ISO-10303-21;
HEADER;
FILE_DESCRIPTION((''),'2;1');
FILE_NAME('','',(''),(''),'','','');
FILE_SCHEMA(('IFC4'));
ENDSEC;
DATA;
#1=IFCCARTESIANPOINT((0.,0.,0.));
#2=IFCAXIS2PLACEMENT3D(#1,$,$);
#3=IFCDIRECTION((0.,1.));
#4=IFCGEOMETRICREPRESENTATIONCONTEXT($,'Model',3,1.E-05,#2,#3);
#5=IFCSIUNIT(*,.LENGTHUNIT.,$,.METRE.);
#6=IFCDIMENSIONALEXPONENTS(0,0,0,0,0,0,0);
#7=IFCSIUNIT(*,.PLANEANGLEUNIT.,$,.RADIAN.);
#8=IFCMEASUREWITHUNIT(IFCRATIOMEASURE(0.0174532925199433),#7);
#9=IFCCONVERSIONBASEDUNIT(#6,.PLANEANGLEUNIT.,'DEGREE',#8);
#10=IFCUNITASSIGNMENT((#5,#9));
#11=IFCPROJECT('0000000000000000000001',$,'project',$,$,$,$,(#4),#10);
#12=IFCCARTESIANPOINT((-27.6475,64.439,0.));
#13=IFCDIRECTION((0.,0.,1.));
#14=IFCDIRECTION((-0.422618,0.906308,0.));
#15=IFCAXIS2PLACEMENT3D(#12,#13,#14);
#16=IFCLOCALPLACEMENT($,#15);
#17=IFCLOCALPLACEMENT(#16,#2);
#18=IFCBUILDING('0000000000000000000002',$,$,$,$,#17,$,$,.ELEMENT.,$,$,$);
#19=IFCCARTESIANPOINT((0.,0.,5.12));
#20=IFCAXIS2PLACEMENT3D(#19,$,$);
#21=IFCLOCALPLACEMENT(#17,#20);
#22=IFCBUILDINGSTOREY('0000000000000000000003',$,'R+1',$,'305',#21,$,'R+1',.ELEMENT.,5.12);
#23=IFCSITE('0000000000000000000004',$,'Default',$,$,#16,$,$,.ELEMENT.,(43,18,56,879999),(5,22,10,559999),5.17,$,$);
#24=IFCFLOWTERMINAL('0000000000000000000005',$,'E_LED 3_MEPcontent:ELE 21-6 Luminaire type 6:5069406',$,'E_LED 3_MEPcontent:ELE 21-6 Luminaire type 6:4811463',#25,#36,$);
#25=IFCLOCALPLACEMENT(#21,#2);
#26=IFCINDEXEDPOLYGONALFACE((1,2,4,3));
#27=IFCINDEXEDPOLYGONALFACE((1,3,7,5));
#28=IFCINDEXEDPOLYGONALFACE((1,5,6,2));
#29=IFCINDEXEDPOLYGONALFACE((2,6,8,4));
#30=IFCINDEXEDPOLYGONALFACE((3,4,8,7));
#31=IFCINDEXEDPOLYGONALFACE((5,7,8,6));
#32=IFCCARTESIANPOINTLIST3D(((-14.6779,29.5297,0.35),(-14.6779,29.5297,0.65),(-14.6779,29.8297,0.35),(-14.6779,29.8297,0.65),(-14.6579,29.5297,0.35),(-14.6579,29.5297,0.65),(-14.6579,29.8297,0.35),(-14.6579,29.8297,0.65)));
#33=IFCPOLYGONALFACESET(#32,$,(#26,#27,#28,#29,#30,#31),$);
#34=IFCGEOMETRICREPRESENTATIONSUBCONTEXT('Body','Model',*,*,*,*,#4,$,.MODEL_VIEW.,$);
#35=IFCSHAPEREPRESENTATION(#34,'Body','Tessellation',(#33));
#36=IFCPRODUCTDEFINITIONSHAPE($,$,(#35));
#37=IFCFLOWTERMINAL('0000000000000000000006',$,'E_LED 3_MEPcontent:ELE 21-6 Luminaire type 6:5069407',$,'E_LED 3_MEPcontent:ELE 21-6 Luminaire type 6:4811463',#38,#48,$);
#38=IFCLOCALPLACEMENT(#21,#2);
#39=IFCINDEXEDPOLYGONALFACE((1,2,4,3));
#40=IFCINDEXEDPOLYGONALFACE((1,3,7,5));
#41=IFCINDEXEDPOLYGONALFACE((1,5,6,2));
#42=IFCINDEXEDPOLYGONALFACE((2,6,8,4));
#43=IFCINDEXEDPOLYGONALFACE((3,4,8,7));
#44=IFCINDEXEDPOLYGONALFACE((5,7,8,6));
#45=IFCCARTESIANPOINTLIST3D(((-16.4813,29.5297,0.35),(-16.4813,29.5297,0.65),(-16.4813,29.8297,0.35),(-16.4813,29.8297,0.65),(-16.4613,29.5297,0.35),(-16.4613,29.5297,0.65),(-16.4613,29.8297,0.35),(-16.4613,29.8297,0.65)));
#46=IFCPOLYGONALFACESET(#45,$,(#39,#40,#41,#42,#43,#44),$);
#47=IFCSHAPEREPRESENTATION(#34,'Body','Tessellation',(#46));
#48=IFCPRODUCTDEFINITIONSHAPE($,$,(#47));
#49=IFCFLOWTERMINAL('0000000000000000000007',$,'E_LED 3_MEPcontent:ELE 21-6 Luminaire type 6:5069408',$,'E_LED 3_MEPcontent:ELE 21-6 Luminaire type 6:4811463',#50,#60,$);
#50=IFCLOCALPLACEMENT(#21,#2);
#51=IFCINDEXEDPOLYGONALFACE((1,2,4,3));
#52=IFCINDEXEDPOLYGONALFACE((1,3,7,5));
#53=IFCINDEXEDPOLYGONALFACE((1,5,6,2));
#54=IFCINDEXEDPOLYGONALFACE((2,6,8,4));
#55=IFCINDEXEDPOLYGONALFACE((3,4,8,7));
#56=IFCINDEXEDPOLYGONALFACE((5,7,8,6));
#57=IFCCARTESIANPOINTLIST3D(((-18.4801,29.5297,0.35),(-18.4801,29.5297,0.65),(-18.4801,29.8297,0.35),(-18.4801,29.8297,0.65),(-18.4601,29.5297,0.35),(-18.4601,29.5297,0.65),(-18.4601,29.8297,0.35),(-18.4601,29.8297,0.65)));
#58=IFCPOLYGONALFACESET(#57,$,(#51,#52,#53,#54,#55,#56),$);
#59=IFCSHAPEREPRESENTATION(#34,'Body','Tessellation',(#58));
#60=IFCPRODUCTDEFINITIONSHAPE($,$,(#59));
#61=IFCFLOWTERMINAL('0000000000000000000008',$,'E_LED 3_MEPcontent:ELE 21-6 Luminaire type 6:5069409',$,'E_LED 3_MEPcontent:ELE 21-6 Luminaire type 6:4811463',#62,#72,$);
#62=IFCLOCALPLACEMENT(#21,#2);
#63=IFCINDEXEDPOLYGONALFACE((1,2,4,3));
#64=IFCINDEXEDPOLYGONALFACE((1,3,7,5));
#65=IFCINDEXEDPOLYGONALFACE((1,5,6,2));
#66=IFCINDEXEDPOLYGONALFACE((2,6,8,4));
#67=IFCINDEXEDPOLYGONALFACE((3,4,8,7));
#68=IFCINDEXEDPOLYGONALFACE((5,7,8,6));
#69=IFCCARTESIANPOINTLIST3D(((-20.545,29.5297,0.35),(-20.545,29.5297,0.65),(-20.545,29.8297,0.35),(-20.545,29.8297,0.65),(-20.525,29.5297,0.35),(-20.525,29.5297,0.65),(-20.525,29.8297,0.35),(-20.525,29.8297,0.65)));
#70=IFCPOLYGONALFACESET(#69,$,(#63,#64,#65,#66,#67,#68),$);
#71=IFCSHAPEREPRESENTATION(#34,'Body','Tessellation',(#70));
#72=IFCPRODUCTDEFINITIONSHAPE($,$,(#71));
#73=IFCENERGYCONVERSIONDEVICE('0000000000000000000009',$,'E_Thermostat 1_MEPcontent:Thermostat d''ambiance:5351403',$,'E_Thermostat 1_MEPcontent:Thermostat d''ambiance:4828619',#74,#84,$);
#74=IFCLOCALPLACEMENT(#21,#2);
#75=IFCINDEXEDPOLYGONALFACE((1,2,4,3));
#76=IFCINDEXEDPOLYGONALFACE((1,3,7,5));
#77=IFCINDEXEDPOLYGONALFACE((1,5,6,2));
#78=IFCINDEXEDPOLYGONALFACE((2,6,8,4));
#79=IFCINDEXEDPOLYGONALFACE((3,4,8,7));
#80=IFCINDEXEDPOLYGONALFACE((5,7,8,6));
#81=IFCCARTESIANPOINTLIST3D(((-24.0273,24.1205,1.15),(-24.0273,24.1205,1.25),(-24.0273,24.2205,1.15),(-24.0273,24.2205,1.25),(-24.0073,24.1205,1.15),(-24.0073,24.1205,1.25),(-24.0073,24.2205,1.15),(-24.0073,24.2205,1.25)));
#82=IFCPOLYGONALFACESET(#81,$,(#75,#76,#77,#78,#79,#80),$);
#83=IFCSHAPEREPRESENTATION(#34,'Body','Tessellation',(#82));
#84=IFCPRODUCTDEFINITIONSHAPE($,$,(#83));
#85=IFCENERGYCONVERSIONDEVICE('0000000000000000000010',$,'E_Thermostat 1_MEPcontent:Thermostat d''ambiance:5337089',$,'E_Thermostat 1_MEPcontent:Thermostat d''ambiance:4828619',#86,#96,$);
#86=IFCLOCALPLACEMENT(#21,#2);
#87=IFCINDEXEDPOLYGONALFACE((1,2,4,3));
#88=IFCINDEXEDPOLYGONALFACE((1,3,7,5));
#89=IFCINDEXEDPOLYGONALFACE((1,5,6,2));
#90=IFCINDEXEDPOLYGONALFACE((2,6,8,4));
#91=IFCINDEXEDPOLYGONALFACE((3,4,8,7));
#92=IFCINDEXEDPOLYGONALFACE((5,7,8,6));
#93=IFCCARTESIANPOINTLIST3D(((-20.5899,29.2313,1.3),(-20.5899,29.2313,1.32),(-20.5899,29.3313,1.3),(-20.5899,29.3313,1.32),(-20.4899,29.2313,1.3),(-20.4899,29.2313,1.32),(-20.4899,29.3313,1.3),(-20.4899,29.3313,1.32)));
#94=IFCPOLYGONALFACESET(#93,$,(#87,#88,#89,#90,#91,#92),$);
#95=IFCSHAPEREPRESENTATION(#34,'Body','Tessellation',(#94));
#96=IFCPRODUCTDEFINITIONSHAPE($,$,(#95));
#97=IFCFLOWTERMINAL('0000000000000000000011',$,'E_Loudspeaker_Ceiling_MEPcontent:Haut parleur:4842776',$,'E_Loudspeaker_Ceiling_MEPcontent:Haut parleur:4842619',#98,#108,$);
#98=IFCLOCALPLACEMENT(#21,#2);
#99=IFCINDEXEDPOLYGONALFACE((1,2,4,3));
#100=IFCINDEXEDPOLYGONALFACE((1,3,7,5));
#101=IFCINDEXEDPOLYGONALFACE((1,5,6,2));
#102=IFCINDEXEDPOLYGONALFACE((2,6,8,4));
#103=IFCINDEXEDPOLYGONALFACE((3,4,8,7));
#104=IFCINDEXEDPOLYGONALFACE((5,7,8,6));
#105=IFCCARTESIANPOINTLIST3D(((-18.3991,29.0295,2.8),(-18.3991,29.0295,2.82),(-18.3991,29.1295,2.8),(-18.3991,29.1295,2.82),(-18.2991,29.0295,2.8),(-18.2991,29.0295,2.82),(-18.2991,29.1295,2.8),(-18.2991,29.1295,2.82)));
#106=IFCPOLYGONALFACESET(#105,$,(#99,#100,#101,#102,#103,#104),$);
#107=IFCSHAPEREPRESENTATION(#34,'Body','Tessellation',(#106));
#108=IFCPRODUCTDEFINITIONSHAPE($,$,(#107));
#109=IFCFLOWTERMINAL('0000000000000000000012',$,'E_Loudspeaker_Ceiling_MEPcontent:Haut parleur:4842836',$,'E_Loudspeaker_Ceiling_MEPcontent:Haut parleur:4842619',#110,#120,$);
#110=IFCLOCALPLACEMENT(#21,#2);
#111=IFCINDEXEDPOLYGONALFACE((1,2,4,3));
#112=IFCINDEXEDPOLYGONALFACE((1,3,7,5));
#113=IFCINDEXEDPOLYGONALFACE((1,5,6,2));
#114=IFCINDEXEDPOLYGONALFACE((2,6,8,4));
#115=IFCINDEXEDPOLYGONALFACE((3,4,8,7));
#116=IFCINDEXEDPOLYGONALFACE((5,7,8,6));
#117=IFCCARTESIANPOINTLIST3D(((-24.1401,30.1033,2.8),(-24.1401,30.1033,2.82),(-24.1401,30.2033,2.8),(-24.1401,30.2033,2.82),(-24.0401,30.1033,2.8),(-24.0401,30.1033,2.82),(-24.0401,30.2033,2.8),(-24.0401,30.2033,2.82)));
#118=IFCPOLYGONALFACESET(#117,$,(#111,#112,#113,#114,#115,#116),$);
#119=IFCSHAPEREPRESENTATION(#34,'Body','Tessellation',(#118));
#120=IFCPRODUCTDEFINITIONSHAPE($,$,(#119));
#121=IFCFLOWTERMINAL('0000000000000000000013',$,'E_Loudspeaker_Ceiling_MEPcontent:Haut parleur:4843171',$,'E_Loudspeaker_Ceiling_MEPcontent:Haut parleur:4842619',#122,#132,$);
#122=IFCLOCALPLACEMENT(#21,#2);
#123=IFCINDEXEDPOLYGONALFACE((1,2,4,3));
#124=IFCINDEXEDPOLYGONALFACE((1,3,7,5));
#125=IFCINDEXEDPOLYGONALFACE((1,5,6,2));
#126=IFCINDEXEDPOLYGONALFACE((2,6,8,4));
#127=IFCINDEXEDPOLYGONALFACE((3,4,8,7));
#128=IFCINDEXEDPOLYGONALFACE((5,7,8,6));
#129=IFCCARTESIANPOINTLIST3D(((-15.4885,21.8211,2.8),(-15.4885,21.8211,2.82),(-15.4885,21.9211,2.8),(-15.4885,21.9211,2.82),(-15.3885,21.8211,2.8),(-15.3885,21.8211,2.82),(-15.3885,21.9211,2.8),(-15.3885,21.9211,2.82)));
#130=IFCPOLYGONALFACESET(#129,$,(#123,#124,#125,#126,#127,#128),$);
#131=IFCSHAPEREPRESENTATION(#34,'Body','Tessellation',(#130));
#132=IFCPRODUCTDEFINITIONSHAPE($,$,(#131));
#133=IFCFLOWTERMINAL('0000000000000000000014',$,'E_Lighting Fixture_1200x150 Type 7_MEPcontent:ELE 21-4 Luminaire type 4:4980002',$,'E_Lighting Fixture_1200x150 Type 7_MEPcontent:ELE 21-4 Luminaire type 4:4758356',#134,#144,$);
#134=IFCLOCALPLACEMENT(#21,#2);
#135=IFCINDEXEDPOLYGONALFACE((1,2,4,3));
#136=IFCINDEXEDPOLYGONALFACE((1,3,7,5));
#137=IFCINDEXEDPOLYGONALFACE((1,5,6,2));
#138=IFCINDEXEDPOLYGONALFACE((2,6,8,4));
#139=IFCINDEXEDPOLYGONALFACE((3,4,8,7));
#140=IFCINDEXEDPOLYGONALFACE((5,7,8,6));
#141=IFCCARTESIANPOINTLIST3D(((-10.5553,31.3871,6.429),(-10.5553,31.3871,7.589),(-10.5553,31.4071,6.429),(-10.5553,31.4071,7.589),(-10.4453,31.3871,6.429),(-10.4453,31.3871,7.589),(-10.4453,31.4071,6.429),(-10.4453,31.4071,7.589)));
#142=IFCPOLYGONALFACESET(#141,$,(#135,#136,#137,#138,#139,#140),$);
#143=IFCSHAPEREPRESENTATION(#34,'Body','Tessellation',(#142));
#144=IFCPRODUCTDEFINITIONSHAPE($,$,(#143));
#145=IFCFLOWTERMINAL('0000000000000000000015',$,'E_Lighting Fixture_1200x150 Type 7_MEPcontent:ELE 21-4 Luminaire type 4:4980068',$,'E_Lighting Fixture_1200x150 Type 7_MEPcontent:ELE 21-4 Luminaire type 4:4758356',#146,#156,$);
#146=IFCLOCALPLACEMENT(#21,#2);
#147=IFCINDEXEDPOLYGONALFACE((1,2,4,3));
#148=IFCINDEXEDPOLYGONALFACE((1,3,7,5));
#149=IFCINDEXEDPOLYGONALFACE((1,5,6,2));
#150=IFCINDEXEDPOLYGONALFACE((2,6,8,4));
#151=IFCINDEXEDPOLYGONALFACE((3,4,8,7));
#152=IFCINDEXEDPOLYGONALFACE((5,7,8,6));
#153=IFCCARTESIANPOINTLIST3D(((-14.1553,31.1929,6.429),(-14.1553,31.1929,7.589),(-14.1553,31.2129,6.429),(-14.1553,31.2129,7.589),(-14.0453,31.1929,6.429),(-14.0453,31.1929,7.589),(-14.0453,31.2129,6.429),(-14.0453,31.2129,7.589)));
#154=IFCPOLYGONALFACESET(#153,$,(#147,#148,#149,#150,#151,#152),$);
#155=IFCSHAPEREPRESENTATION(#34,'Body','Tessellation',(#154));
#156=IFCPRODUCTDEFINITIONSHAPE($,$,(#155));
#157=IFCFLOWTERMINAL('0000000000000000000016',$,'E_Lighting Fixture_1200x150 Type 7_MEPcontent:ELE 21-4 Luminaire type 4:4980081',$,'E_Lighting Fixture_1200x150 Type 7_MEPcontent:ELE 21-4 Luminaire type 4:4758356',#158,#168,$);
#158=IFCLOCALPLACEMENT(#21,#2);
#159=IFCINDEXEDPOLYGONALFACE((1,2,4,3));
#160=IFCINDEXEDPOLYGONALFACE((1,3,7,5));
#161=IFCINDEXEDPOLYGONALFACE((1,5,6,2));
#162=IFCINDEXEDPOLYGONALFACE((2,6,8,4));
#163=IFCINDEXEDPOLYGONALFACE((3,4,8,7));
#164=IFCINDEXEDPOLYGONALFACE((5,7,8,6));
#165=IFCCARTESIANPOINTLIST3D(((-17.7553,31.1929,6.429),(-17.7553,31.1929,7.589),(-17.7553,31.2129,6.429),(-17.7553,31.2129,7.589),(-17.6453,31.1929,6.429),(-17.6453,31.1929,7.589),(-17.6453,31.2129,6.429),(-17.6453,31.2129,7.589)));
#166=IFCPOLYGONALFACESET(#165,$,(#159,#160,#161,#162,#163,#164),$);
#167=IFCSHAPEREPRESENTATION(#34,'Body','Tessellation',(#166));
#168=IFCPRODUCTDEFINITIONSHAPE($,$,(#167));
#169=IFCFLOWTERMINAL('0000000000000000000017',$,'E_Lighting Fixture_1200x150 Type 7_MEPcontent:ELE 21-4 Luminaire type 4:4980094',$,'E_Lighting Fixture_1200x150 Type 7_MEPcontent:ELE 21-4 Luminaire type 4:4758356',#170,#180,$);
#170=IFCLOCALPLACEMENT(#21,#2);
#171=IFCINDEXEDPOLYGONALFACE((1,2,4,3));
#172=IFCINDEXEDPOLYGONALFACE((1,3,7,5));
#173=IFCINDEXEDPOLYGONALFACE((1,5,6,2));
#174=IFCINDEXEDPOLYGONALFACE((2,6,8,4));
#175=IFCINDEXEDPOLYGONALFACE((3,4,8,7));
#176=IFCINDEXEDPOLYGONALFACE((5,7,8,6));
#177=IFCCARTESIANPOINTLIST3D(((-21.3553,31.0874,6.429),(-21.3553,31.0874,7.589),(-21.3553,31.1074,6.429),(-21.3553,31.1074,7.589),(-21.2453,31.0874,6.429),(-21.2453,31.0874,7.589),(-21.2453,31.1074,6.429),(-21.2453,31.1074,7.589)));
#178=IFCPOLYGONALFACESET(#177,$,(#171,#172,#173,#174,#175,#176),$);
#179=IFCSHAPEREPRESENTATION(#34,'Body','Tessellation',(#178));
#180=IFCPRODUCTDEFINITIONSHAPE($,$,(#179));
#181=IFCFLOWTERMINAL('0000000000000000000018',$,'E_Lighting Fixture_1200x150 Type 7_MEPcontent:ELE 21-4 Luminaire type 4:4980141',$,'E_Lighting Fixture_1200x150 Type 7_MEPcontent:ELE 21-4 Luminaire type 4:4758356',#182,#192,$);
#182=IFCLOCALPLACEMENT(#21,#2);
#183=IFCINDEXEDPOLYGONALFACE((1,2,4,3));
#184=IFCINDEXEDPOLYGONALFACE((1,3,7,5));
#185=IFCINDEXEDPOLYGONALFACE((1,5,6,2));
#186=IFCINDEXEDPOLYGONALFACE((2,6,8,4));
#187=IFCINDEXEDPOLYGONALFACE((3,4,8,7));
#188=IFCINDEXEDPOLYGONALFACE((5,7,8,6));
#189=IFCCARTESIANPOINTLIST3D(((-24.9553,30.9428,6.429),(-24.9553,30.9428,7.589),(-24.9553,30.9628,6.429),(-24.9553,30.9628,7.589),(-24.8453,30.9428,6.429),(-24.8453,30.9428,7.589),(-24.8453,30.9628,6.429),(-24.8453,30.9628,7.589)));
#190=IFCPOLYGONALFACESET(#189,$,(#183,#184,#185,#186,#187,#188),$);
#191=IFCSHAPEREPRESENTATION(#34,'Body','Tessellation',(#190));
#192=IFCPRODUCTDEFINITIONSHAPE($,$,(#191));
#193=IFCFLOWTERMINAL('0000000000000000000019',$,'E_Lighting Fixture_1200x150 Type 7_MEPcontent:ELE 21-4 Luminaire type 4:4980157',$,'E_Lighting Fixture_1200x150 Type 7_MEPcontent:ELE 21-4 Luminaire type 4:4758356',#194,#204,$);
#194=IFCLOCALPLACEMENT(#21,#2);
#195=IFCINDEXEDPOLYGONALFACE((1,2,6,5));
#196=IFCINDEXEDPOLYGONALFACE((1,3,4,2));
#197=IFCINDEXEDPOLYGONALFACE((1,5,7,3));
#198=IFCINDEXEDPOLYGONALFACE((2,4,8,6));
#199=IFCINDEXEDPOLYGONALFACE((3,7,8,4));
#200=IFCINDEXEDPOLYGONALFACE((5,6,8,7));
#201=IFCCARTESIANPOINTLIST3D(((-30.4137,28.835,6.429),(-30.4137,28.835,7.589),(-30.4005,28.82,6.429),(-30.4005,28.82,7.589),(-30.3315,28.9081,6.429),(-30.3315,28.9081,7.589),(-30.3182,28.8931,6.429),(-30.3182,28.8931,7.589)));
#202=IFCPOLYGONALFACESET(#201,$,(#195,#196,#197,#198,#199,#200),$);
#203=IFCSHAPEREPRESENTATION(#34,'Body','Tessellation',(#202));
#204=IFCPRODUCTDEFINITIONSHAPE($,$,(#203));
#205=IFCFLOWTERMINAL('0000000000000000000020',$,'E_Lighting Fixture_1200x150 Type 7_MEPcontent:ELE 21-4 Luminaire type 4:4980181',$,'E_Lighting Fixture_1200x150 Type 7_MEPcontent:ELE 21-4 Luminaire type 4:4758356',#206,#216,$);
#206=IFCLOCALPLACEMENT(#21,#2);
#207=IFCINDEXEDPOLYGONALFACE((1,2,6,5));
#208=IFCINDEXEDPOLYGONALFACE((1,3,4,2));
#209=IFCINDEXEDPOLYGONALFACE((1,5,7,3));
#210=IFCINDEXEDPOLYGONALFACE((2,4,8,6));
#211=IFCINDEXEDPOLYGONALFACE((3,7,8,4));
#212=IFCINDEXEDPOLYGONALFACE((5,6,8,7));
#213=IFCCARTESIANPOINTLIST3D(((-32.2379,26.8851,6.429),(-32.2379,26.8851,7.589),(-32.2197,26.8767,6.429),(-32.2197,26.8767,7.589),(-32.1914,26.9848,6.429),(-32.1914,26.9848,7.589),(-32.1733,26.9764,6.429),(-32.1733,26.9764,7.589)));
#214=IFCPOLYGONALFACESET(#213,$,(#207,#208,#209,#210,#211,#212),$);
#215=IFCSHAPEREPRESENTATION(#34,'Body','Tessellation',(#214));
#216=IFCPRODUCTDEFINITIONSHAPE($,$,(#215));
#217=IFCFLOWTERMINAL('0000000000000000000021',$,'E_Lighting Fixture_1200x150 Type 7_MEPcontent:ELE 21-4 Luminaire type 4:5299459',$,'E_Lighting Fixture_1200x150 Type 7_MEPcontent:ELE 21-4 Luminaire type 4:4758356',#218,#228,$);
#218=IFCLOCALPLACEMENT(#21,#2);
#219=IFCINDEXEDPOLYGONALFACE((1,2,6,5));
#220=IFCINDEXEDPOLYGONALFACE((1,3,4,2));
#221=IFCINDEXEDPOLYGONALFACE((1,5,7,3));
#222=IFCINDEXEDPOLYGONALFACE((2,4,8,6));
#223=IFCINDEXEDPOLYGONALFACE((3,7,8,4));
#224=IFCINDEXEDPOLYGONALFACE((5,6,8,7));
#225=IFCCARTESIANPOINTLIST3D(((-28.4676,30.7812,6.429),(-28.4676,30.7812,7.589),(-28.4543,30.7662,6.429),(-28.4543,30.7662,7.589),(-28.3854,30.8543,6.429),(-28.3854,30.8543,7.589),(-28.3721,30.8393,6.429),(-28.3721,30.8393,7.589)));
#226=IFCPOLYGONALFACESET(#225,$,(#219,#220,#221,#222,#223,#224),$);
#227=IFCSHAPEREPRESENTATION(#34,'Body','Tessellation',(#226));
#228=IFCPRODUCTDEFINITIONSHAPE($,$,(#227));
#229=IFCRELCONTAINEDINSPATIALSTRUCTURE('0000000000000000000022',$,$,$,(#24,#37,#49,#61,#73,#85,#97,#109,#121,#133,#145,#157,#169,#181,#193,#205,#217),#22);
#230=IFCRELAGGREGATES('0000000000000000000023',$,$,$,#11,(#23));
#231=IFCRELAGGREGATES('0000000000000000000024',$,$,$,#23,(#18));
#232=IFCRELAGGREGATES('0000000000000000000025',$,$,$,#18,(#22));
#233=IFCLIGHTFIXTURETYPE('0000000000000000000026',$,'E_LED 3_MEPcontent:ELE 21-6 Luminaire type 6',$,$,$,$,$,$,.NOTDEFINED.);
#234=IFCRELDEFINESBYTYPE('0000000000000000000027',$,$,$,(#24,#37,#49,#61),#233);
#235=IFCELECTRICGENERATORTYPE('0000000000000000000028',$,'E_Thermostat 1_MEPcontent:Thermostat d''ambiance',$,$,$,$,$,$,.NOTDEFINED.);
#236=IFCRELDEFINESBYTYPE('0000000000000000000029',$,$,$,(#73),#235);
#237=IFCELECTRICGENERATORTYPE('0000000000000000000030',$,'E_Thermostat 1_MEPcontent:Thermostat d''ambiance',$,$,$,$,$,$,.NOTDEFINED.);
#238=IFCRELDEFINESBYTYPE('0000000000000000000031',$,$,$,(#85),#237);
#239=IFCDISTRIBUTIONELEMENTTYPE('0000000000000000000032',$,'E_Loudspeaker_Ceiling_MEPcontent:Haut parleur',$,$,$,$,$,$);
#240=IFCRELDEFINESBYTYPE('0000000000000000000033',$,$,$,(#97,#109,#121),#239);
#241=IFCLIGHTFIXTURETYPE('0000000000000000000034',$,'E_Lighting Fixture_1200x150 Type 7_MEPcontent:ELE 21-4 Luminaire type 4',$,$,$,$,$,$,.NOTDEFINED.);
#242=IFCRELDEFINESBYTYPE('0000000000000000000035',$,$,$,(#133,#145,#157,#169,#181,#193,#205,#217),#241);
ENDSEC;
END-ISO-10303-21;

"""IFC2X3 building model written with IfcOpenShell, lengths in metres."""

from ifc_helpers import new_model, entity, si_unit, converted_unit, direction, frame, frame_2d, origin, origin_2d_with_axis, place, context, subcontext, project, spatial, rectangle, extrude, source, transform, mapped, type_object, type_shapes, element, save


model = new_model("IFC2X3")

# Units and contexts
model_context = context("Model", 3, precision=1e-05, world=origin(), true_north=direction((0.0, 1.0)))
body_context = subcontext(model_context, "Body", "Model", "MODEL_VIEW")
ifc_project = project(units=[si_unit("LENGTHUNIT", "METRE"), converted_unit("PLANEANGLEUNIT", "DEGREE", entity("IfcRatioMeasure", 0.0174532925199433), si_unit("PLANEANGLEUNIT", "RADIAN"), dimensions=[0, 0, 0, 0, 0, 0, 0])], contexts=[model_context])

# Site, building, storey
site_placement = place(None, frame((-27.6475, 64.439, 0.0), z_axis=(0.0, 0.0, 1.0), x_axis=(-0.422618, 0.906308, 0.0)))
site = spatial("IfcSite", under=ifc_project, at=site_placement, Name="Default", CompositionType="ELEMENT", RefLatitude=(43, 18, 56, 879999), RefLongitude=(5, 22, 10, 559999), RefElevation=5.17)
building_placement = place(site_placement, origin())
building = spatial("IfcBuilding", under=site, at=building_placement, CompositionType="ELEMENT")
storey_placement = place(building_placement, frame((0.0, 0.0, 5.12)))
storey = spatial("IfcBuildingStorey", under=building, at=storey_placement, Name="R+1", ObjectType="305", LongName="R+1", CompositionType="ELEMENT", Elevation=5.12)

# Flow terminals
light_fixture_type_1 = type_object("IfcLightFixtureType", Name="E_LED 3_MEPcontent:ELE 21-6 Luminaire type 6", PredefinedType="NOTDEFINED")
shared_shape_1 = source(origin(), body_context, "Body", "SweptSolid", [
    extrude(rectangle(XDim=0.02, YDim=0.3, at=origin_2d_with_axis()), frame((0.0, 0.01, -0.15), z_axis=(0.0, 0.0, 1.0), x_axis=(0.0, -1.0, 0.0)), (0.0, 0.0, 1.0), 0.3),
])
type_shapes(light_fixture_type_1, [shared_shape_1])
for number, where, z_axis, x_axis, name in (
    (1, (-14.6779, 29.6797, 0.5), (0.0, 0.0, 1.0), (0.0, -1.0, 0.0), "E_LED 3_MEPcontent:ELE 21-6 Luminaire type 6:5069406"),
    (2, (-16.4813, 29.6797, 0.5), (0.0, 0.0, 1.0), (0.0, -1.0, 0.0), "E_LED 3_MEPcontent:ELE 21-6 Luminaire type 6:5069407"),
    (3, (-18.4801, 29.6797, 0.5), (0.0, 0.0, 1.0), (0.0, -1.0, 0.0), "E_LED 3_MEPcontent:ELE 21-6 Luminaire type 6:5069408"),
    (4, (-20.545, 29.6797, 0.5), (0.0, 0.0, 1.0), (0.0, -1.0, 0.0), "E_LED 3_MEPcontent:ELE 21-6 Luminaire type 6:5069409"),
):
    element("IfcFlowTerminal", number, at=place(storey_placement, frame(where, z_axis=z_axis, x_axis=x_axis)), inside=storey, type_object=light_fixture_type_1, Name=name, ObjectType="E_LED 3_MEPcontent:ELE 21-6 Luminaire type 6:4811463", context=body_context, shape_type="MappedRepresentation", body=[
        mapped(shared_shape_1, transform((0.0, 0.0, 0.0), scale=1.0)),
    ])

# Energy conversion devices
electric_generator_type_1 = type_object("IfcElectricGeneratorType", Name="E_Thermostat 1_MEPcontent:Thermostat d'ambiance", PredefinedType="NOTDEFINED")
shared_shape_2 = source(origin(), body_context, "Body", "SweptSolid", [
    extrude(rectangle(XDim=0.02, YDim=0.1, at=frame_2d((0.0, 0.0), x_axis=(1.0, 0.0))), frame((0.0, 0.01, -0.05), z_axis=(0.0, 0.0, 1.0), x_axis=(0.0, -1.0, 0.0)), (0.0, 0.0, 1.0), 0.1),
])
type_shapes(electric_generator_type_1, [shared_shape_2])
energy_conversion_device_1_placement = place(storey_placement, frame((-24.0073, 24.1705, 1.2), z_axis=(0.0, 0.0, 1.0), x_axis=(0.0, 1.0, 0.0)))
element("IfcEnergyConversionDevice", 5, at=energy_conversion_device_1_placement, inside=storey, type_object=electric_generator_type_1, Name="E_Thermostat 1_MEPcontent:Thermostat d'ambiance:5351403", ObjectType="E_Thermostat 1_MEPcontent:Thermostat d'ambiance:4828619", context=body_context, shape_type="MappedRepresentation", body=[
    mapped(shared_shape_2, transform((0.0, 0.0, 0.0), scale=1.0)),
])
electric_generator_type_2 = type_object("IfcElectricGeneratorType", Name="E_Thermostat 1_MEPcontent:Thermostat d'ambiance", PredefinedType="NOTDEFINED")
shared_shape_3 = source(origin(), body_context, "Body", "SweptSolid", [
    extrude(rectangle(XDim=0.1, YDim=0.1, at=origin_2d_with_axis()), frame((0.0, 0.0, 0.0), z_axis=(0.0, 0.0, 1.0), x_axis=(0.0, -1.0, 0.0)), (0.0, 0.0, 1.0), 0.02),
])
type_shapes(electric_generator_type_2, [shared_shape_3])
energy_conversion_device_2_placement = place(storey_placement, frame((-20.5399, 29.2813, 1.3), z_axis=(0.0, 0.0, 1.0), x_axis=(-1.0, 0.0, 0.0)))
element("IfcEnergyConversionDevice", 6, at=energy_conversion_device_2_placement, inside=storey, type_object=electric_generator_type_2, Name="E_Thermostat 1_MEPcontent:Thermostat d'ambiance:5337089", ObjectType="E_Thermostat 1_MEPcontent:Thermostat d'ambiance:4828619", context=body_context, shape_type="MappedRepresentation", body=[
    mapped(shared_shape_3, transform((0.0, 0.0, 0.0), scale=1.0)),
])

# Flow terminals
distribution_element_type = type_object("IfcDistributionElementType", Name="E_Loudspeaker_Ceiling_MEPcontent:Haut parleur")
shared_shape_4 = source(origin(), body_context, "Body", "SweptSolid", [
    extrude(rectangle(XDim=0.1, YDim=0.1, at=origin_2d_with_axis()), frame((0.0, 0.0, 0.0), z_axis=(0.0, 0.0, 1.0), x_axis=(0.0, -1.0, 0.0)), (0.0, 0.0, 1.0), 0.02),
])
type_shapes(distribution_element_type, [shared_shape_4])
for number, where, z_axis, x_axis, name in (
    (7, (-18.3491, 29.0795, 2.8), (0.0, 0.0, 1.0), (-1.0, 0.0, 0.0), "E_Loudspeaker_Ceiling_MEPcontent:Haut parleur:4842776"),
    (8, (-24.0901, 30.1533, 2.8), (0.0, 0.0, 1.0), (0.0, 1.0, 0.0), "E_Loudspeaker_Ceiling_MEPcontent:Haut parleur:4842836"),
    (9, (-15.4385, 21.8711, 2.8), (0.0, 0.0, 1.0), (-1.0, 0.0, 0.0), "E_Loudspeaker_Ceiling_MEPcontent:Haut parleur:4843171"),
):
    element("IfcFlowTerminal", number, at=place(storey_placement, frame(where, z_axis=z_axis, x_axis=x_axis)), inside=storey, type_object=distribution_element_type, Name=name, ObjectType="E_Loudspeaker_Ceiling_MEPcontent:Haut parleur:4842619", context=body_context, shape_type="MappedRepresentation", body=[
        mapped(shared_shape_4, transform((0.0, 0.0, 0.0), scale=1.0)),
    ])
light_fixture_type_2 = type_object("IfcLightFixtureType", Name="E_Lighting Fixture_1200x150 Type 7_MEPcontent:ELE 21-4 Luminaire type 4", PredefinedType="NOTDEFINED")
shared_shape_5 = source(origin(), body_context, "Body", "SweptSolid", [
    extrude(rectangle(XDim=0.02, YDim=0.11, at=frame_2d((0.0, 0.0), x_axis=(1.0, 0.0))), frame((0.01, 0.0, -0.58), z_axis=(0.0, 0.0, 1.0), x_axis=(-1.0, 0.0, 0.0)), (0.0, 0.0, 1.0), 1.16),
])
type_shapes(light_fixture_type_2, [shared_shape_5])
for number, where, z_axis, x_axis, name in (
    (10, (-10.5003, 31.4071, 7.009), (0.0, 0.0, 1.0), (0.0, -1.0, 0.0), "E_Lighting Fixture_1200x150 Type 7_MEPcontent:ELE 21-4 Luminaire type 4:4980002"),
    (11, (-14.1003, 31.2129, 7.009), (0.0, 0.0, 1.0), (0.0, -1.0, 0.0), "E_Lighting Fixture_1200x150 Type 7_MEPcontent:ELE 21-4 Luminaire type 4:4980068"),
    (12, (-17.7003, 31.2129, 7.009), (0.0, 0.0, 1.0), (0.0, -1.0, 0.0), "E_Lighting Fixture_1200x150 Type 7_MEPcontent:ELE 21-4 Luminaire type 4:4980081"),
    (13, (-21.3003, 31.1074, 7.009), (0.0, 0.0, 1.0), (0.0, -1.0, 0.0), "E_Lighting Fixture_1200x150 Type 7_MEPcontent:ELE 21-4 Luminaire type 4:4980094"),
    (14, (-24.9003, 30.9628, 7.009), (0.0, 0.0, 1.0), (0.0, -1.0, 0.0), "E_Lighting Fixture_1200x150 Type 7_MEPcontent:ELE 21-4 Luminaire type 4:4980141"),
    (15, (-30.3726, 28.8715, 7.009), (0.0, 0.0, 1.0), (0.66438, -0.747395, 0.0), "E_Lighting Fixture_1200x150 Type 7_MEPcontent:ELE 21-4 Luminaire type 4:4980157"),
    (16, (-32.2146, 26.935, 7.009), (0.0, 0.0, 1.0), (0.906511, -0.422183, 0.0), "E_Lighting Fixture_1200x150 Type 7_MEPcontent:ELE 21-4 Luminaire type 4:4980181"),
    (17, (-28.4265, 30.8177, 7.009), (0.0, 0.0, 1.0), (0.66438, -0.747395, 0.0), "E_Lighting Fixture_1200x150 Type 7_MEPcontent:ELE 21-4 Luminaire type 4:5299459"),
):
    element("IfcFlowTerminal", number, at=place(storey_placement, frame(where, z_axis=z_axis, x_axis=x_axis)), inside=storey, type_object=light_fixture_type_2, Name=name, ObjectType="E_Lighting Fixture_1200x150 Type 7_MEPcontent:ELE 21-4 Luminaire type 4:4758356", context=body_context, shape_type="MappedRepresentation", body=[
        mapped(shared_shape_5, transform((0.0, 0.0, 0.0), scale=1.0)),
    ])

save(model, "model.ifc")
